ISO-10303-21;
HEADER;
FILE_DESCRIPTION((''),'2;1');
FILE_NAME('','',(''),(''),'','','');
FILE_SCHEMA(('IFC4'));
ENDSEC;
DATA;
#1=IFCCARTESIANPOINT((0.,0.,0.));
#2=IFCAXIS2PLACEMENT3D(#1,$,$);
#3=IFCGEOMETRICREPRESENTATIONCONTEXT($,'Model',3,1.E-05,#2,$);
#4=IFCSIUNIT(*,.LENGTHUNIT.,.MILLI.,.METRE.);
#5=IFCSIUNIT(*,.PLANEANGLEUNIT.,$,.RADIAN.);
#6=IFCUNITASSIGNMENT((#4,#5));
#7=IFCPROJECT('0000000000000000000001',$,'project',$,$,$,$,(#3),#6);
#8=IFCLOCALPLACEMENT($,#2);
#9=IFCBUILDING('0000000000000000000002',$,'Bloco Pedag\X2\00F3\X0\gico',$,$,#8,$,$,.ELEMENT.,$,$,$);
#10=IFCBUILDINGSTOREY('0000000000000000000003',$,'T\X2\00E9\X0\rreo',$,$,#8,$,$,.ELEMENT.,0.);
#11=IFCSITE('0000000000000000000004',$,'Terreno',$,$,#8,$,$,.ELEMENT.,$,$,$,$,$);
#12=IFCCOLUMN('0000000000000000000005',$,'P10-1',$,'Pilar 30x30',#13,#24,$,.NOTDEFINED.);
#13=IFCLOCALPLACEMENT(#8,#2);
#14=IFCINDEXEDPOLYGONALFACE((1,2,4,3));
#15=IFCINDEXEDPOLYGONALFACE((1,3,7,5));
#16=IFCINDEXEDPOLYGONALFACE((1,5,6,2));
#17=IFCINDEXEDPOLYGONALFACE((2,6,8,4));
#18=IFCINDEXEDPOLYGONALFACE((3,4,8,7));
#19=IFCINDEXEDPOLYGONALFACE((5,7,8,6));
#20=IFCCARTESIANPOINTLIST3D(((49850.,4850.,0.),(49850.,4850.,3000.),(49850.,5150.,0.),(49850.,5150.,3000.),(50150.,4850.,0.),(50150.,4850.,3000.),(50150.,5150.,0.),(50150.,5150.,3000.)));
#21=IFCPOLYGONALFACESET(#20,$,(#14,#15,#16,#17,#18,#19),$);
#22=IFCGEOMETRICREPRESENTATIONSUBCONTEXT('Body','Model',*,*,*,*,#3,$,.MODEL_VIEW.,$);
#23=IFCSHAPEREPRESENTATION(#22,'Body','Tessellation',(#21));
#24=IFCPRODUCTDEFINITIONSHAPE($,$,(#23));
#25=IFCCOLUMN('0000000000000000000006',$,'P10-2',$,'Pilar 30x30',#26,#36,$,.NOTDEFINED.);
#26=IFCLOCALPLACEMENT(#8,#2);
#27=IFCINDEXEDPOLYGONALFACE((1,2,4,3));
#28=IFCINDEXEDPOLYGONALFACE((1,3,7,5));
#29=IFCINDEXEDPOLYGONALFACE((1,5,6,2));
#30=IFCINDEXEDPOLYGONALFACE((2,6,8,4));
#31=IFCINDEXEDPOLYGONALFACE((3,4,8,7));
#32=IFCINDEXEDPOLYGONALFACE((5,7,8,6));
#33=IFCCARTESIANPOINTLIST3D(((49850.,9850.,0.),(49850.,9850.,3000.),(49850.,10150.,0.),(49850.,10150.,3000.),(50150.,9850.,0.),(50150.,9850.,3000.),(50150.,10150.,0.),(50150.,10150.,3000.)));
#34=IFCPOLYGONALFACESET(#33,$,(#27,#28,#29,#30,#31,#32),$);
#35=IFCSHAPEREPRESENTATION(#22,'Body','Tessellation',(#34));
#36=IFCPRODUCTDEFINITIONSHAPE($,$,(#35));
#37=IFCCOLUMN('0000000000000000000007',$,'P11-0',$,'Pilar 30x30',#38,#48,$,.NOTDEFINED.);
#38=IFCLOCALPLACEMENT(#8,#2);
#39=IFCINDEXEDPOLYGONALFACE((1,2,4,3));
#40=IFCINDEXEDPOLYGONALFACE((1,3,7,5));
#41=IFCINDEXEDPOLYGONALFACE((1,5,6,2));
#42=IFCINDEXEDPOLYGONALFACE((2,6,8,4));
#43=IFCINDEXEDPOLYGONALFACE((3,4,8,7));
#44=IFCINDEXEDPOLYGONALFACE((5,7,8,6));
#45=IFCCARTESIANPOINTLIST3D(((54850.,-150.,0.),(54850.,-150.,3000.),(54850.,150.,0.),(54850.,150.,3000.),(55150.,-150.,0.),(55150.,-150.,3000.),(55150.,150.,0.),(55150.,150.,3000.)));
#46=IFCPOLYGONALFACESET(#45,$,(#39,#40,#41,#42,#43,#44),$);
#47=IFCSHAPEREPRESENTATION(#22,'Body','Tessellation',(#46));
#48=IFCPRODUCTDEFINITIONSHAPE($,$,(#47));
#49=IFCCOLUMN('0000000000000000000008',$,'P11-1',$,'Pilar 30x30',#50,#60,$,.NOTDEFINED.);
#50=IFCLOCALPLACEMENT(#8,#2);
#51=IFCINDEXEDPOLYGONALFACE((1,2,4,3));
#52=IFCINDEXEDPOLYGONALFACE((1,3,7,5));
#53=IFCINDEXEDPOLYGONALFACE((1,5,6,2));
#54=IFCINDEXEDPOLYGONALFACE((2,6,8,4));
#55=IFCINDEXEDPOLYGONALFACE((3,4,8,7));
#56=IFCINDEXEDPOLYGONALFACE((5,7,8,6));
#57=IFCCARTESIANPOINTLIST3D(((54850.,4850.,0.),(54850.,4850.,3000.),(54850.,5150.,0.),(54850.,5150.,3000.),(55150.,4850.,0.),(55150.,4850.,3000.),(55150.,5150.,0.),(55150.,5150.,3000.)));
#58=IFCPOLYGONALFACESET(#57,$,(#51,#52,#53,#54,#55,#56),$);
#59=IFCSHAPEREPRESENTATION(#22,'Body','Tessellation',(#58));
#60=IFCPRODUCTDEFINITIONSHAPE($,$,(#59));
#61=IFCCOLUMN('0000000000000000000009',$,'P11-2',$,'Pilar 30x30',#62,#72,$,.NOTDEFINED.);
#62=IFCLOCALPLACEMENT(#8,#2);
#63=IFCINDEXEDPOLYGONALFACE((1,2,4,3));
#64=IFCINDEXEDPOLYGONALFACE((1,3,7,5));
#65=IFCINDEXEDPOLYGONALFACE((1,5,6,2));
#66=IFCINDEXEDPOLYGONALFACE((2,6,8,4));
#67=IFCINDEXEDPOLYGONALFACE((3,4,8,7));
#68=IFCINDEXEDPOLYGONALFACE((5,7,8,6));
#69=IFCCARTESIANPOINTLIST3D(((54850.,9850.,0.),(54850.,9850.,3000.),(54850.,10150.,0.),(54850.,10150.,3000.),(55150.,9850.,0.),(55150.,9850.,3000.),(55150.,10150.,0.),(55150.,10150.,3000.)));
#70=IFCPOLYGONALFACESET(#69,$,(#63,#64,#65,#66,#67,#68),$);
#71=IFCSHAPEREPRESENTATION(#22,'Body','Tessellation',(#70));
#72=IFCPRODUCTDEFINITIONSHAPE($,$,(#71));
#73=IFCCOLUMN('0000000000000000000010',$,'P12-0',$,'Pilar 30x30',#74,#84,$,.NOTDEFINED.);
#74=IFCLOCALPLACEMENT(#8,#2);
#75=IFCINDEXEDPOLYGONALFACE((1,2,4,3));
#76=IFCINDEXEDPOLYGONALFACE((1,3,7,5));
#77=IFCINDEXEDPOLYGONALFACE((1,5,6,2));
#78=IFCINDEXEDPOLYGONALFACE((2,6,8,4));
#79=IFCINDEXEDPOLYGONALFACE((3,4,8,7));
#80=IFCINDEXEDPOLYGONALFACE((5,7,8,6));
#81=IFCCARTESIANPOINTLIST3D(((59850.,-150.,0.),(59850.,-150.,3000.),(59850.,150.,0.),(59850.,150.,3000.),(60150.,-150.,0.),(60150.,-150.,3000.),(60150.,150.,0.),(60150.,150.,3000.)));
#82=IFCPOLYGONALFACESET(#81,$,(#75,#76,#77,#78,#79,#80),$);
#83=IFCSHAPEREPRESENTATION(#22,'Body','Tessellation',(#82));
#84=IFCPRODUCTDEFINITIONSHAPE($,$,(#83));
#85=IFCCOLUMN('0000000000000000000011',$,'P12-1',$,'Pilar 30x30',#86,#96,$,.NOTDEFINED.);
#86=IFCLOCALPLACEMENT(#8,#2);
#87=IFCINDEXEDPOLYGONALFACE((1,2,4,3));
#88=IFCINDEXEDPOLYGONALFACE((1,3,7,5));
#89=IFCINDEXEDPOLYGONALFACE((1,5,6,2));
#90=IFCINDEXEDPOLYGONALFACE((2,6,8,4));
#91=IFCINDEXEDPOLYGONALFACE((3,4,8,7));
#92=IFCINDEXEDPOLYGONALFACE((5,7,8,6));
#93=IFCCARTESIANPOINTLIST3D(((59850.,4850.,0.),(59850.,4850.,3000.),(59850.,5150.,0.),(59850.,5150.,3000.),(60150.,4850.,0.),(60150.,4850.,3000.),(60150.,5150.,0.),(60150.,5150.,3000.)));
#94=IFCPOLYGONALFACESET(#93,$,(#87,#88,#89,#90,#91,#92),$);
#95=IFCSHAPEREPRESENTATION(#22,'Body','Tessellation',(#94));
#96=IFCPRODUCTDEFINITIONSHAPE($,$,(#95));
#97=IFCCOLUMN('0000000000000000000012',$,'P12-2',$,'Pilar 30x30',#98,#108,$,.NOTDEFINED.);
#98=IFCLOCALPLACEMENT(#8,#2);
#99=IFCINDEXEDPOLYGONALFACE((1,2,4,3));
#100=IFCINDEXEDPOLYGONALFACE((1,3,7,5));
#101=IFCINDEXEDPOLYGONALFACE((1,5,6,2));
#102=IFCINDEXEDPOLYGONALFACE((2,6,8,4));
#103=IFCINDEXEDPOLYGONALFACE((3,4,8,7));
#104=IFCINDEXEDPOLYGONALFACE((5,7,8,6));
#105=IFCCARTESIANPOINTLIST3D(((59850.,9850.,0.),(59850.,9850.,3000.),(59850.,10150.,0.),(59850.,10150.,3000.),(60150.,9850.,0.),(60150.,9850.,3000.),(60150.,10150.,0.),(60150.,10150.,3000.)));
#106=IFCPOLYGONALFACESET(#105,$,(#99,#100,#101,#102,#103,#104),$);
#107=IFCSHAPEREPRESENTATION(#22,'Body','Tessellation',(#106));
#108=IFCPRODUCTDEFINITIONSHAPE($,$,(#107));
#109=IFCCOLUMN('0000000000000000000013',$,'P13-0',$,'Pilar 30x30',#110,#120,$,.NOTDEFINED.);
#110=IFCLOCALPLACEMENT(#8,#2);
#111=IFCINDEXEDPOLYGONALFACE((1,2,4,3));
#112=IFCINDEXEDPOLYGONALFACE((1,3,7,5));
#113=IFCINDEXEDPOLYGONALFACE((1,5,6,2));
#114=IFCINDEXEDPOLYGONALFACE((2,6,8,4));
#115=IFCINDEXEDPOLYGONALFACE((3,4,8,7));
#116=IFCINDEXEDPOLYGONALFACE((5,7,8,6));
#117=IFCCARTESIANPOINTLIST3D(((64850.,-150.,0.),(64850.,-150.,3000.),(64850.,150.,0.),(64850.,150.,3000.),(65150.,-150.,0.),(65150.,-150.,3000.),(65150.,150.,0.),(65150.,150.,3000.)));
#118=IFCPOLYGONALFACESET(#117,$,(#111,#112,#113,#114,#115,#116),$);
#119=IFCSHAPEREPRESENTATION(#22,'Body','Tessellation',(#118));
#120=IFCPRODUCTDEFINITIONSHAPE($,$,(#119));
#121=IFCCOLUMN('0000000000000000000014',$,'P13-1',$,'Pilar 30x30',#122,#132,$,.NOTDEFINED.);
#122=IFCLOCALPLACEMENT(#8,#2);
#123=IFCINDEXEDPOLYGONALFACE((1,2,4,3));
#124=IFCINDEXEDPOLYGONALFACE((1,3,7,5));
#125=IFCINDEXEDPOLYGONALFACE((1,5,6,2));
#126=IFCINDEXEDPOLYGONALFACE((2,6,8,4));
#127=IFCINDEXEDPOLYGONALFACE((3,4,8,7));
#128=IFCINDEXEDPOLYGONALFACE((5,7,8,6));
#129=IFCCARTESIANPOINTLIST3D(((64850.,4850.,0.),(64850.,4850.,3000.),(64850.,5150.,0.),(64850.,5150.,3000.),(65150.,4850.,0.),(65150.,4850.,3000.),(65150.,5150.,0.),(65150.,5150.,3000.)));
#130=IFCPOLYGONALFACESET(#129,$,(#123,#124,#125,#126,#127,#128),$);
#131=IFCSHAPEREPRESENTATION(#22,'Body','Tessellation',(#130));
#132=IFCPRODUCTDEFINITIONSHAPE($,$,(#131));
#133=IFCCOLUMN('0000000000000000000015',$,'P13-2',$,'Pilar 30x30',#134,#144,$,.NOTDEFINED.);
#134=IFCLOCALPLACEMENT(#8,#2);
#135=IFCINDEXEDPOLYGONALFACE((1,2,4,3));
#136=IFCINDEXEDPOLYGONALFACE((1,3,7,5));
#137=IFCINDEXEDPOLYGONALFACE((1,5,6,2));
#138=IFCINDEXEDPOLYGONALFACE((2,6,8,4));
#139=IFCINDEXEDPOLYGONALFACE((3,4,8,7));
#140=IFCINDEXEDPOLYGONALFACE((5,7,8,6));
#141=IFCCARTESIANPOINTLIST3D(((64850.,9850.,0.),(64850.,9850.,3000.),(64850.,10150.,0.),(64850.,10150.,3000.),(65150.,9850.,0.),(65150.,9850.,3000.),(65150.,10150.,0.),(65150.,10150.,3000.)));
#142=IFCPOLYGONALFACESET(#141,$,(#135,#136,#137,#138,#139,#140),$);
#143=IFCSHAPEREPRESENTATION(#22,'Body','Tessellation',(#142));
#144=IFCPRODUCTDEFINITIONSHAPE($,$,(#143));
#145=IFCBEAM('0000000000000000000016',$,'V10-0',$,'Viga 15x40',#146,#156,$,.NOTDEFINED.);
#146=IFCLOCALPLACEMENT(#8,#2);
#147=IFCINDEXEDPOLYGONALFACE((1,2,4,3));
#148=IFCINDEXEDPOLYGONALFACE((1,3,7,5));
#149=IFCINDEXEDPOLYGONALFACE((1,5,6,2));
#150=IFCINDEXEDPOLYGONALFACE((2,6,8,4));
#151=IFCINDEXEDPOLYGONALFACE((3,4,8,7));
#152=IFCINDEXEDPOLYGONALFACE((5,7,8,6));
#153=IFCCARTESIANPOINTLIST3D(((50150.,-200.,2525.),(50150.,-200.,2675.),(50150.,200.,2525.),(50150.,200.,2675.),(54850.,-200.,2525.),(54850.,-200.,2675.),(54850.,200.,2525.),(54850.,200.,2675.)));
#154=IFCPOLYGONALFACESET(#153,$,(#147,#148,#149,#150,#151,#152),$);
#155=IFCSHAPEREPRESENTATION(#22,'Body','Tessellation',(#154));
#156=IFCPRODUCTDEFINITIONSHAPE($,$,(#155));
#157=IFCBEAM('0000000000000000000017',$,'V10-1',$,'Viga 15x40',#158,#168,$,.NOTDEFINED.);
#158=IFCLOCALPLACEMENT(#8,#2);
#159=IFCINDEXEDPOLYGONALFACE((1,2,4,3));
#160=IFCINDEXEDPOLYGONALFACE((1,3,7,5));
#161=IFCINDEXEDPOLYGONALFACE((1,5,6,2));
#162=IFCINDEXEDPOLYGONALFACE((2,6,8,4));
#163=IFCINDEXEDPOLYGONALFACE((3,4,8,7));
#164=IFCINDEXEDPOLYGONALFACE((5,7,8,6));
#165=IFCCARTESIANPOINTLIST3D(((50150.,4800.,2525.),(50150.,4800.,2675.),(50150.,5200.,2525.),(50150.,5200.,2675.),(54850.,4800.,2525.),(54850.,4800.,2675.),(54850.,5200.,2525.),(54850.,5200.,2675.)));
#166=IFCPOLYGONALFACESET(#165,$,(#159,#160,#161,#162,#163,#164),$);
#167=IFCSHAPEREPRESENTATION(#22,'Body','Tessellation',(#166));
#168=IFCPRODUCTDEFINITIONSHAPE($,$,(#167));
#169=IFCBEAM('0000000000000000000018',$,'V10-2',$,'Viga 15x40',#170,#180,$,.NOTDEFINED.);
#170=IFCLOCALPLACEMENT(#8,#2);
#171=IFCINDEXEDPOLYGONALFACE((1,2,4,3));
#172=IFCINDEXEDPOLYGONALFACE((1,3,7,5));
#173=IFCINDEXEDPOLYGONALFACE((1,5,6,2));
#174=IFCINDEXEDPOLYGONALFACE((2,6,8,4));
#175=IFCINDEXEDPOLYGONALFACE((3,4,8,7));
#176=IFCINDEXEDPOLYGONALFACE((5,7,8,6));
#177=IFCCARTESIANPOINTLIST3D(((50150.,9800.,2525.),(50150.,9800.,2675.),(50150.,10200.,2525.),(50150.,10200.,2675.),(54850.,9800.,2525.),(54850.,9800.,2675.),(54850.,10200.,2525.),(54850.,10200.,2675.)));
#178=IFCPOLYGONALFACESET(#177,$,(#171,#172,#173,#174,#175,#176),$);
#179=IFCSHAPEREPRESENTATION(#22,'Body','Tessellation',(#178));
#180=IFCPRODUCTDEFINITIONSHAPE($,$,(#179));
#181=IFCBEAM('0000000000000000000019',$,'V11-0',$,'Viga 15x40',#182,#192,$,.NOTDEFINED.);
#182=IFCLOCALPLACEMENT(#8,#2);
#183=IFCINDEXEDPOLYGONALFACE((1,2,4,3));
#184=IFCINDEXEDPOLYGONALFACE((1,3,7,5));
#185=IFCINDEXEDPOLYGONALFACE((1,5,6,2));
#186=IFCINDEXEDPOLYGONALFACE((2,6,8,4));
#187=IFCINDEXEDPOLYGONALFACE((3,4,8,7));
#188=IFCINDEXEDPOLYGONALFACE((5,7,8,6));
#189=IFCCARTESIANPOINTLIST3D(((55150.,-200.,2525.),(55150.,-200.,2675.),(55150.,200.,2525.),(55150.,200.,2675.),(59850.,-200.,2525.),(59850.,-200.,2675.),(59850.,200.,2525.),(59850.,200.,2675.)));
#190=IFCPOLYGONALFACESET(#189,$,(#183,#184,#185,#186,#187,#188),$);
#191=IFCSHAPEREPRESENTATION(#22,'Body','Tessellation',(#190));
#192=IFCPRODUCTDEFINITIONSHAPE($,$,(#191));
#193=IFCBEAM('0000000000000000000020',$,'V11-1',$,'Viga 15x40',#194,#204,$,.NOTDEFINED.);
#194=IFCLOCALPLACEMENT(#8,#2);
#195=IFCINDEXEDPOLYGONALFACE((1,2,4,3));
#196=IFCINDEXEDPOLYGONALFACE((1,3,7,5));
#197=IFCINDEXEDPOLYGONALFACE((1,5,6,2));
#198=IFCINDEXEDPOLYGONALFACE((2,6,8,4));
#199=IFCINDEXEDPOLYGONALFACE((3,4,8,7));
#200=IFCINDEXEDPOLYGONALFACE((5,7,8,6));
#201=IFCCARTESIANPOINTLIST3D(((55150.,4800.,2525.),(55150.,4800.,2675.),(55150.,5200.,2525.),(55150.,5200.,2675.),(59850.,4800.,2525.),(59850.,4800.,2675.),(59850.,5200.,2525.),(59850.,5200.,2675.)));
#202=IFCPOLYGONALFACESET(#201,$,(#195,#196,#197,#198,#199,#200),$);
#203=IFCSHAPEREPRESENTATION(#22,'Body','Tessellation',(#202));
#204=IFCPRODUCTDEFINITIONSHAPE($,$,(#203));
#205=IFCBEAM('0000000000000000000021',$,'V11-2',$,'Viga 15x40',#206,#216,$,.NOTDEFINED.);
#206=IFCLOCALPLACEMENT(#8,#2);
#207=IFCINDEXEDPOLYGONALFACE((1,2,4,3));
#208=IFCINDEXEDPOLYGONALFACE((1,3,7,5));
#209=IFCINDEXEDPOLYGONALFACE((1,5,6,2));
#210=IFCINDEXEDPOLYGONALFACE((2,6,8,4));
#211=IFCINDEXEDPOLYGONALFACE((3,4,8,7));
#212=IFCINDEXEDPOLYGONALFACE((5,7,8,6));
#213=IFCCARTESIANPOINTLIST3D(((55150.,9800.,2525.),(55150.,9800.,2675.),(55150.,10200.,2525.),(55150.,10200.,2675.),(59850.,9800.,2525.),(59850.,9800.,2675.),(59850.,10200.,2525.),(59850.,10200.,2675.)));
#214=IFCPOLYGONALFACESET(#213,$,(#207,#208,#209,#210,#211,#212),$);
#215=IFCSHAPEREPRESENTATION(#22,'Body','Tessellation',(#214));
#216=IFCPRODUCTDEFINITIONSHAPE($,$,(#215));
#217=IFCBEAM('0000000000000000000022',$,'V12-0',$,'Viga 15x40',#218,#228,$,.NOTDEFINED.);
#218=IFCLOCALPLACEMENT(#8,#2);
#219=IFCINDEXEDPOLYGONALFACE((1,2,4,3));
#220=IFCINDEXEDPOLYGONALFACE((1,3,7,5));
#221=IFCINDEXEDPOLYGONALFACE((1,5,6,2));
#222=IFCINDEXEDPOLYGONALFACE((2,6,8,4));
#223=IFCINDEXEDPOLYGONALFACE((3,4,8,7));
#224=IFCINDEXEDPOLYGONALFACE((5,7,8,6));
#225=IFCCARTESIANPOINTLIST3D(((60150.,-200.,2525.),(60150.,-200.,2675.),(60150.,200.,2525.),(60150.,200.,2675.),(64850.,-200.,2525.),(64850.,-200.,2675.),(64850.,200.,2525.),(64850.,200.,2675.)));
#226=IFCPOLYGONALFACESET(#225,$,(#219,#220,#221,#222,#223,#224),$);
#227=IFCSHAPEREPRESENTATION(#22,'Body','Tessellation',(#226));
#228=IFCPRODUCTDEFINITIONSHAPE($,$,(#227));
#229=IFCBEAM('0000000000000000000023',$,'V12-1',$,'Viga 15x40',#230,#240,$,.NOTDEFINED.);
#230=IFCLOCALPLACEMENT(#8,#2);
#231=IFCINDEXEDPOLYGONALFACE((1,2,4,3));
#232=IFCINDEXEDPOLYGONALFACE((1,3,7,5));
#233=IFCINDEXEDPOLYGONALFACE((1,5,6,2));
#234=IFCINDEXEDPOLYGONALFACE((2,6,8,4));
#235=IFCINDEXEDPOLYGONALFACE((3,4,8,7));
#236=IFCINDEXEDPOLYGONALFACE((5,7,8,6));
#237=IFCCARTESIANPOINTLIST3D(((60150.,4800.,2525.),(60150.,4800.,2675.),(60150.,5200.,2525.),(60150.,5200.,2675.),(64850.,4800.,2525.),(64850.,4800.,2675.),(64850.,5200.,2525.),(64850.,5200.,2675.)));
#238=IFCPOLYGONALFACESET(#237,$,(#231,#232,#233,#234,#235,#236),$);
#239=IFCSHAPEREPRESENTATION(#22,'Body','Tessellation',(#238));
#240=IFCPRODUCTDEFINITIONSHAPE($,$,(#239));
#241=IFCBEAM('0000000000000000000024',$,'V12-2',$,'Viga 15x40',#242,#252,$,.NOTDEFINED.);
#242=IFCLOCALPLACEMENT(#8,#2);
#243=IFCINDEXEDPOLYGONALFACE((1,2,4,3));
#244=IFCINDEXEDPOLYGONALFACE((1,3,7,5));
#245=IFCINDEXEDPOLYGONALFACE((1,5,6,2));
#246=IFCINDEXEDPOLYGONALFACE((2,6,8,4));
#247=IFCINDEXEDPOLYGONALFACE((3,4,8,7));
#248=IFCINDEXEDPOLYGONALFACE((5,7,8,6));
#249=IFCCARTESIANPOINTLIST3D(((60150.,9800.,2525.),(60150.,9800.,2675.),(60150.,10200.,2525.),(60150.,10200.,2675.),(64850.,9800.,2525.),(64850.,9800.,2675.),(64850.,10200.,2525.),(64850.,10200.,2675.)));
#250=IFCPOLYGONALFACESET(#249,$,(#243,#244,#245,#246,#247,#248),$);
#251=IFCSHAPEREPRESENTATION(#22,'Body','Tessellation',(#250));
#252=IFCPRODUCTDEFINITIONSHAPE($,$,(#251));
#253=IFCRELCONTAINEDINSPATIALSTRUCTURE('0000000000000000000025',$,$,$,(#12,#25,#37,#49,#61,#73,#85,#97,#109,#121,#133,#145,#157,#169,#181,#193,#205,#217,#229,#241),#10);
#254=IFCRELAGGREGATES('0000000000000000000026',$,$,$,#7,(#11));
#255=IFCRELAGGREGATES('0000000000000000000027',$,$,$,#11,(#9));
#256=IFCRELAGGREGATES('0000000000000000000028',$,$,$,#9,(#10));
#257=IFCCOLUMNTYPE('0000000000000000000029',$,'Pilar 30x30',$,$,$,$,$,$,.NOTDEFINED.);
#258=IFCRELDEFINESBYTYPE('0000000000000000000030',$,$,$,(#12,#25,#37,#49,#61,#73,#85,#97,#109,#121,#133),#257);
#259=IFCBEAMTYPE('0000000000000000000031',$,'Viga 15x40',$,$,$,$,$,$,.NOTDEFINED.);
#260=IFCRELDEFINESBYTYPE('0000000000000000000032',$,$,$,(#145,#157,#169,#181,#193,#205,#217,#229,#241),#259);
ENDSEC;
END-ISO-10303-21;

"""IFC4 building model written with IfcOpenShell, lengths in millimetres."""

from ifc_helpers import new_model, si_unit, frame, origin, origin_2d, place, context, subcontext, project, spatial, rectangle, extrude, type_object, element, save


model = new_model("IFC4")

# Units and contexts
model_context = context("Model", 3, precision=1e-05, world=origin())
body_context = subcontext(model_context, "Body", "Model", "MODEL_VIEW")
ifc_project = project(units=[si_unit("LENGTHUNIT", "METRE", prefix="MILLI"), si_unit("PLANEANGLEUNIT", "RADIAN")], contexts=[model_context])

# Site, building, storey
placement = place(None, origin())
site = spatial("IfcSite", under=ifc_project, at=placement, Name="Terreno", CompositionType="ELEMENT")
building = spatial("IfcBuilding", under=site, at=placement, Name="Bloco Pedagógico", CompositionType="ELEMENT")
storey = spatial("IfcBuildingStorey", under=building, at=placement, Name="Térreo", CompositionType="ELEMENT", Elevation=0.0)

# Columns
column_type = type_object("IfcColumnType", Name="Pilar 30x30", PredefinedType="NOTDEFINED")
for number, where, z_axis, x_axis, name in (
    (1, (50000.0, 5000.0, 0.0), (0.0, 0.0, 1.0), (1.0, 0.0, 0.0), "P10-1"),
    (2, (50000.0, 10000.0, 0.0), (0.0, 0.0, 1.0), (1.0, 0.0, 0.0), "P10-2"),
    (3, (55000.0, 0.0, 0.0), (0.0, 0.0, 1.0), (1.0, 0.0, 0.0), "P11-0"),
    (4, (55000.0, 5000.0, 0.0), (0.0, 0.0, 1.0), (1.0, 0.0, 0.0), "P11-1"),
    (5, (55000.0, 10000.0, 0.0), (0.0, 0.0, 1.0), (1.0, 0.0, 0.0), "P11-2"),
    (6, (60000.0, 0.0, 0.0), (0.0, 0.0, 1.0), (1.0, 0.0, 0.0), "P12-0"),
    (7, (60000.0, 5000.0, 0.0), (0.0, 0.0, 1.0), (1.0, 0.0, 0.0), "P12-1"),
    (8, (60000.0, 10000.0, 0.0), (0.0, 0.0, 1.0), (1.0, 0.0, 0.0), "P12-2"),
    (9, (65000.0, 0.0, 0.0), (0.0, 0.0, 1.0), (1.0, 0.0, 0.0), "P13-0"),
    (10, (65000.0, 5000.0, 0.0), (0.0, 0.0, 1.0), (1.0, 0.0, 0.0), "P13-1"),
    (11, (65000.0, 10000.0, 0.0), (0.0, 0.0, 1.0), (1.0, 0.0, 0.0), "P13-2"),
):
    element("IfcColumn", number, at=place(None, frame(where, z_axis=z_axis, x_axis=x_axis)), inside=storey, type_object=column_type, Name=name, ObjectType="Pilar 30x30", PredefinedType="NOTDEFINED", context=body_context, shape_type="SweptSolid", body=[
        extrude(rectangle(XDim=300.0, YDim=300.0, at=origin_2d()), None, (0.0, 0.0, 1.0), 3000.0),
    ])

# Beams
beam_type = type_object("IfcBeamType", Name="Viga 15x40", PredefinedType="NOTDEFINED")
for number, where, z_axis, x_axis, name in (
    (12, (50150.0, 0.0, 2600.0), (1.0, 0.0, 0.0), (0.0, 1.0, 0.0), "V10-0"),
    (13, (50150.0, 5000.0, 2600.0), (1.0, 0.0, 0.0), (0.0, 1.0, 0.0), "V10-1"),
    (14, (50150.0, 10000.0, 2600.0), (1.0, 0.0, 0.0), (0.0, 1.0, 0.0), "V10-2"),
    (15, (55150.0, 0.0, 2600.0), (1.0, 0.0, 0.0), (0.0, 1.0, 0.0), "V11-0"),
    (16, (55150.0, 5000.0, 2600.0), (1.0, 0.0, 0.0), (0.0, 1.0, 0.0), "V11-1"),
    (17, (55150.0, 10000.0, 2600.0), (1.0, 0.0, 0.0), (0.0, 1.0, 0.0), "V11-2"),
    (18, (60150.0, 0.0, 2600.0), (1.0, 0.0, 0.0), (0.0, 1.0, 0.0), "V12-0"),
    (19, (60150.0, 5000.0, 2600.0), (1.0, 0.0, 0.0), (0.0, 1.0, 0.0), "V12-1"),
    (20, (60150.0, 10000.0, 2600.0), (1.0, 0.0, 0.0), (0.0, 1.0, 0.0), "V12-2"),
):
    element("IfcBeam", number, at=place(None, frame(where, z_axis=z_axis, x_axis=x_axis)), inside=storey, type_object=beam_type, Name=name, ObjectType="Viga 15x40", PredefinedType="NOTDEFINED", context=body_context, shape_type="SweptSolid", body=[
        extrude(rectangle(XDim=400.0, YDim=150.0, at=origin_2d()), None, (0.0, 0.0, 1.0), 4700.0),
    ])

save(model, "model.ifc")
